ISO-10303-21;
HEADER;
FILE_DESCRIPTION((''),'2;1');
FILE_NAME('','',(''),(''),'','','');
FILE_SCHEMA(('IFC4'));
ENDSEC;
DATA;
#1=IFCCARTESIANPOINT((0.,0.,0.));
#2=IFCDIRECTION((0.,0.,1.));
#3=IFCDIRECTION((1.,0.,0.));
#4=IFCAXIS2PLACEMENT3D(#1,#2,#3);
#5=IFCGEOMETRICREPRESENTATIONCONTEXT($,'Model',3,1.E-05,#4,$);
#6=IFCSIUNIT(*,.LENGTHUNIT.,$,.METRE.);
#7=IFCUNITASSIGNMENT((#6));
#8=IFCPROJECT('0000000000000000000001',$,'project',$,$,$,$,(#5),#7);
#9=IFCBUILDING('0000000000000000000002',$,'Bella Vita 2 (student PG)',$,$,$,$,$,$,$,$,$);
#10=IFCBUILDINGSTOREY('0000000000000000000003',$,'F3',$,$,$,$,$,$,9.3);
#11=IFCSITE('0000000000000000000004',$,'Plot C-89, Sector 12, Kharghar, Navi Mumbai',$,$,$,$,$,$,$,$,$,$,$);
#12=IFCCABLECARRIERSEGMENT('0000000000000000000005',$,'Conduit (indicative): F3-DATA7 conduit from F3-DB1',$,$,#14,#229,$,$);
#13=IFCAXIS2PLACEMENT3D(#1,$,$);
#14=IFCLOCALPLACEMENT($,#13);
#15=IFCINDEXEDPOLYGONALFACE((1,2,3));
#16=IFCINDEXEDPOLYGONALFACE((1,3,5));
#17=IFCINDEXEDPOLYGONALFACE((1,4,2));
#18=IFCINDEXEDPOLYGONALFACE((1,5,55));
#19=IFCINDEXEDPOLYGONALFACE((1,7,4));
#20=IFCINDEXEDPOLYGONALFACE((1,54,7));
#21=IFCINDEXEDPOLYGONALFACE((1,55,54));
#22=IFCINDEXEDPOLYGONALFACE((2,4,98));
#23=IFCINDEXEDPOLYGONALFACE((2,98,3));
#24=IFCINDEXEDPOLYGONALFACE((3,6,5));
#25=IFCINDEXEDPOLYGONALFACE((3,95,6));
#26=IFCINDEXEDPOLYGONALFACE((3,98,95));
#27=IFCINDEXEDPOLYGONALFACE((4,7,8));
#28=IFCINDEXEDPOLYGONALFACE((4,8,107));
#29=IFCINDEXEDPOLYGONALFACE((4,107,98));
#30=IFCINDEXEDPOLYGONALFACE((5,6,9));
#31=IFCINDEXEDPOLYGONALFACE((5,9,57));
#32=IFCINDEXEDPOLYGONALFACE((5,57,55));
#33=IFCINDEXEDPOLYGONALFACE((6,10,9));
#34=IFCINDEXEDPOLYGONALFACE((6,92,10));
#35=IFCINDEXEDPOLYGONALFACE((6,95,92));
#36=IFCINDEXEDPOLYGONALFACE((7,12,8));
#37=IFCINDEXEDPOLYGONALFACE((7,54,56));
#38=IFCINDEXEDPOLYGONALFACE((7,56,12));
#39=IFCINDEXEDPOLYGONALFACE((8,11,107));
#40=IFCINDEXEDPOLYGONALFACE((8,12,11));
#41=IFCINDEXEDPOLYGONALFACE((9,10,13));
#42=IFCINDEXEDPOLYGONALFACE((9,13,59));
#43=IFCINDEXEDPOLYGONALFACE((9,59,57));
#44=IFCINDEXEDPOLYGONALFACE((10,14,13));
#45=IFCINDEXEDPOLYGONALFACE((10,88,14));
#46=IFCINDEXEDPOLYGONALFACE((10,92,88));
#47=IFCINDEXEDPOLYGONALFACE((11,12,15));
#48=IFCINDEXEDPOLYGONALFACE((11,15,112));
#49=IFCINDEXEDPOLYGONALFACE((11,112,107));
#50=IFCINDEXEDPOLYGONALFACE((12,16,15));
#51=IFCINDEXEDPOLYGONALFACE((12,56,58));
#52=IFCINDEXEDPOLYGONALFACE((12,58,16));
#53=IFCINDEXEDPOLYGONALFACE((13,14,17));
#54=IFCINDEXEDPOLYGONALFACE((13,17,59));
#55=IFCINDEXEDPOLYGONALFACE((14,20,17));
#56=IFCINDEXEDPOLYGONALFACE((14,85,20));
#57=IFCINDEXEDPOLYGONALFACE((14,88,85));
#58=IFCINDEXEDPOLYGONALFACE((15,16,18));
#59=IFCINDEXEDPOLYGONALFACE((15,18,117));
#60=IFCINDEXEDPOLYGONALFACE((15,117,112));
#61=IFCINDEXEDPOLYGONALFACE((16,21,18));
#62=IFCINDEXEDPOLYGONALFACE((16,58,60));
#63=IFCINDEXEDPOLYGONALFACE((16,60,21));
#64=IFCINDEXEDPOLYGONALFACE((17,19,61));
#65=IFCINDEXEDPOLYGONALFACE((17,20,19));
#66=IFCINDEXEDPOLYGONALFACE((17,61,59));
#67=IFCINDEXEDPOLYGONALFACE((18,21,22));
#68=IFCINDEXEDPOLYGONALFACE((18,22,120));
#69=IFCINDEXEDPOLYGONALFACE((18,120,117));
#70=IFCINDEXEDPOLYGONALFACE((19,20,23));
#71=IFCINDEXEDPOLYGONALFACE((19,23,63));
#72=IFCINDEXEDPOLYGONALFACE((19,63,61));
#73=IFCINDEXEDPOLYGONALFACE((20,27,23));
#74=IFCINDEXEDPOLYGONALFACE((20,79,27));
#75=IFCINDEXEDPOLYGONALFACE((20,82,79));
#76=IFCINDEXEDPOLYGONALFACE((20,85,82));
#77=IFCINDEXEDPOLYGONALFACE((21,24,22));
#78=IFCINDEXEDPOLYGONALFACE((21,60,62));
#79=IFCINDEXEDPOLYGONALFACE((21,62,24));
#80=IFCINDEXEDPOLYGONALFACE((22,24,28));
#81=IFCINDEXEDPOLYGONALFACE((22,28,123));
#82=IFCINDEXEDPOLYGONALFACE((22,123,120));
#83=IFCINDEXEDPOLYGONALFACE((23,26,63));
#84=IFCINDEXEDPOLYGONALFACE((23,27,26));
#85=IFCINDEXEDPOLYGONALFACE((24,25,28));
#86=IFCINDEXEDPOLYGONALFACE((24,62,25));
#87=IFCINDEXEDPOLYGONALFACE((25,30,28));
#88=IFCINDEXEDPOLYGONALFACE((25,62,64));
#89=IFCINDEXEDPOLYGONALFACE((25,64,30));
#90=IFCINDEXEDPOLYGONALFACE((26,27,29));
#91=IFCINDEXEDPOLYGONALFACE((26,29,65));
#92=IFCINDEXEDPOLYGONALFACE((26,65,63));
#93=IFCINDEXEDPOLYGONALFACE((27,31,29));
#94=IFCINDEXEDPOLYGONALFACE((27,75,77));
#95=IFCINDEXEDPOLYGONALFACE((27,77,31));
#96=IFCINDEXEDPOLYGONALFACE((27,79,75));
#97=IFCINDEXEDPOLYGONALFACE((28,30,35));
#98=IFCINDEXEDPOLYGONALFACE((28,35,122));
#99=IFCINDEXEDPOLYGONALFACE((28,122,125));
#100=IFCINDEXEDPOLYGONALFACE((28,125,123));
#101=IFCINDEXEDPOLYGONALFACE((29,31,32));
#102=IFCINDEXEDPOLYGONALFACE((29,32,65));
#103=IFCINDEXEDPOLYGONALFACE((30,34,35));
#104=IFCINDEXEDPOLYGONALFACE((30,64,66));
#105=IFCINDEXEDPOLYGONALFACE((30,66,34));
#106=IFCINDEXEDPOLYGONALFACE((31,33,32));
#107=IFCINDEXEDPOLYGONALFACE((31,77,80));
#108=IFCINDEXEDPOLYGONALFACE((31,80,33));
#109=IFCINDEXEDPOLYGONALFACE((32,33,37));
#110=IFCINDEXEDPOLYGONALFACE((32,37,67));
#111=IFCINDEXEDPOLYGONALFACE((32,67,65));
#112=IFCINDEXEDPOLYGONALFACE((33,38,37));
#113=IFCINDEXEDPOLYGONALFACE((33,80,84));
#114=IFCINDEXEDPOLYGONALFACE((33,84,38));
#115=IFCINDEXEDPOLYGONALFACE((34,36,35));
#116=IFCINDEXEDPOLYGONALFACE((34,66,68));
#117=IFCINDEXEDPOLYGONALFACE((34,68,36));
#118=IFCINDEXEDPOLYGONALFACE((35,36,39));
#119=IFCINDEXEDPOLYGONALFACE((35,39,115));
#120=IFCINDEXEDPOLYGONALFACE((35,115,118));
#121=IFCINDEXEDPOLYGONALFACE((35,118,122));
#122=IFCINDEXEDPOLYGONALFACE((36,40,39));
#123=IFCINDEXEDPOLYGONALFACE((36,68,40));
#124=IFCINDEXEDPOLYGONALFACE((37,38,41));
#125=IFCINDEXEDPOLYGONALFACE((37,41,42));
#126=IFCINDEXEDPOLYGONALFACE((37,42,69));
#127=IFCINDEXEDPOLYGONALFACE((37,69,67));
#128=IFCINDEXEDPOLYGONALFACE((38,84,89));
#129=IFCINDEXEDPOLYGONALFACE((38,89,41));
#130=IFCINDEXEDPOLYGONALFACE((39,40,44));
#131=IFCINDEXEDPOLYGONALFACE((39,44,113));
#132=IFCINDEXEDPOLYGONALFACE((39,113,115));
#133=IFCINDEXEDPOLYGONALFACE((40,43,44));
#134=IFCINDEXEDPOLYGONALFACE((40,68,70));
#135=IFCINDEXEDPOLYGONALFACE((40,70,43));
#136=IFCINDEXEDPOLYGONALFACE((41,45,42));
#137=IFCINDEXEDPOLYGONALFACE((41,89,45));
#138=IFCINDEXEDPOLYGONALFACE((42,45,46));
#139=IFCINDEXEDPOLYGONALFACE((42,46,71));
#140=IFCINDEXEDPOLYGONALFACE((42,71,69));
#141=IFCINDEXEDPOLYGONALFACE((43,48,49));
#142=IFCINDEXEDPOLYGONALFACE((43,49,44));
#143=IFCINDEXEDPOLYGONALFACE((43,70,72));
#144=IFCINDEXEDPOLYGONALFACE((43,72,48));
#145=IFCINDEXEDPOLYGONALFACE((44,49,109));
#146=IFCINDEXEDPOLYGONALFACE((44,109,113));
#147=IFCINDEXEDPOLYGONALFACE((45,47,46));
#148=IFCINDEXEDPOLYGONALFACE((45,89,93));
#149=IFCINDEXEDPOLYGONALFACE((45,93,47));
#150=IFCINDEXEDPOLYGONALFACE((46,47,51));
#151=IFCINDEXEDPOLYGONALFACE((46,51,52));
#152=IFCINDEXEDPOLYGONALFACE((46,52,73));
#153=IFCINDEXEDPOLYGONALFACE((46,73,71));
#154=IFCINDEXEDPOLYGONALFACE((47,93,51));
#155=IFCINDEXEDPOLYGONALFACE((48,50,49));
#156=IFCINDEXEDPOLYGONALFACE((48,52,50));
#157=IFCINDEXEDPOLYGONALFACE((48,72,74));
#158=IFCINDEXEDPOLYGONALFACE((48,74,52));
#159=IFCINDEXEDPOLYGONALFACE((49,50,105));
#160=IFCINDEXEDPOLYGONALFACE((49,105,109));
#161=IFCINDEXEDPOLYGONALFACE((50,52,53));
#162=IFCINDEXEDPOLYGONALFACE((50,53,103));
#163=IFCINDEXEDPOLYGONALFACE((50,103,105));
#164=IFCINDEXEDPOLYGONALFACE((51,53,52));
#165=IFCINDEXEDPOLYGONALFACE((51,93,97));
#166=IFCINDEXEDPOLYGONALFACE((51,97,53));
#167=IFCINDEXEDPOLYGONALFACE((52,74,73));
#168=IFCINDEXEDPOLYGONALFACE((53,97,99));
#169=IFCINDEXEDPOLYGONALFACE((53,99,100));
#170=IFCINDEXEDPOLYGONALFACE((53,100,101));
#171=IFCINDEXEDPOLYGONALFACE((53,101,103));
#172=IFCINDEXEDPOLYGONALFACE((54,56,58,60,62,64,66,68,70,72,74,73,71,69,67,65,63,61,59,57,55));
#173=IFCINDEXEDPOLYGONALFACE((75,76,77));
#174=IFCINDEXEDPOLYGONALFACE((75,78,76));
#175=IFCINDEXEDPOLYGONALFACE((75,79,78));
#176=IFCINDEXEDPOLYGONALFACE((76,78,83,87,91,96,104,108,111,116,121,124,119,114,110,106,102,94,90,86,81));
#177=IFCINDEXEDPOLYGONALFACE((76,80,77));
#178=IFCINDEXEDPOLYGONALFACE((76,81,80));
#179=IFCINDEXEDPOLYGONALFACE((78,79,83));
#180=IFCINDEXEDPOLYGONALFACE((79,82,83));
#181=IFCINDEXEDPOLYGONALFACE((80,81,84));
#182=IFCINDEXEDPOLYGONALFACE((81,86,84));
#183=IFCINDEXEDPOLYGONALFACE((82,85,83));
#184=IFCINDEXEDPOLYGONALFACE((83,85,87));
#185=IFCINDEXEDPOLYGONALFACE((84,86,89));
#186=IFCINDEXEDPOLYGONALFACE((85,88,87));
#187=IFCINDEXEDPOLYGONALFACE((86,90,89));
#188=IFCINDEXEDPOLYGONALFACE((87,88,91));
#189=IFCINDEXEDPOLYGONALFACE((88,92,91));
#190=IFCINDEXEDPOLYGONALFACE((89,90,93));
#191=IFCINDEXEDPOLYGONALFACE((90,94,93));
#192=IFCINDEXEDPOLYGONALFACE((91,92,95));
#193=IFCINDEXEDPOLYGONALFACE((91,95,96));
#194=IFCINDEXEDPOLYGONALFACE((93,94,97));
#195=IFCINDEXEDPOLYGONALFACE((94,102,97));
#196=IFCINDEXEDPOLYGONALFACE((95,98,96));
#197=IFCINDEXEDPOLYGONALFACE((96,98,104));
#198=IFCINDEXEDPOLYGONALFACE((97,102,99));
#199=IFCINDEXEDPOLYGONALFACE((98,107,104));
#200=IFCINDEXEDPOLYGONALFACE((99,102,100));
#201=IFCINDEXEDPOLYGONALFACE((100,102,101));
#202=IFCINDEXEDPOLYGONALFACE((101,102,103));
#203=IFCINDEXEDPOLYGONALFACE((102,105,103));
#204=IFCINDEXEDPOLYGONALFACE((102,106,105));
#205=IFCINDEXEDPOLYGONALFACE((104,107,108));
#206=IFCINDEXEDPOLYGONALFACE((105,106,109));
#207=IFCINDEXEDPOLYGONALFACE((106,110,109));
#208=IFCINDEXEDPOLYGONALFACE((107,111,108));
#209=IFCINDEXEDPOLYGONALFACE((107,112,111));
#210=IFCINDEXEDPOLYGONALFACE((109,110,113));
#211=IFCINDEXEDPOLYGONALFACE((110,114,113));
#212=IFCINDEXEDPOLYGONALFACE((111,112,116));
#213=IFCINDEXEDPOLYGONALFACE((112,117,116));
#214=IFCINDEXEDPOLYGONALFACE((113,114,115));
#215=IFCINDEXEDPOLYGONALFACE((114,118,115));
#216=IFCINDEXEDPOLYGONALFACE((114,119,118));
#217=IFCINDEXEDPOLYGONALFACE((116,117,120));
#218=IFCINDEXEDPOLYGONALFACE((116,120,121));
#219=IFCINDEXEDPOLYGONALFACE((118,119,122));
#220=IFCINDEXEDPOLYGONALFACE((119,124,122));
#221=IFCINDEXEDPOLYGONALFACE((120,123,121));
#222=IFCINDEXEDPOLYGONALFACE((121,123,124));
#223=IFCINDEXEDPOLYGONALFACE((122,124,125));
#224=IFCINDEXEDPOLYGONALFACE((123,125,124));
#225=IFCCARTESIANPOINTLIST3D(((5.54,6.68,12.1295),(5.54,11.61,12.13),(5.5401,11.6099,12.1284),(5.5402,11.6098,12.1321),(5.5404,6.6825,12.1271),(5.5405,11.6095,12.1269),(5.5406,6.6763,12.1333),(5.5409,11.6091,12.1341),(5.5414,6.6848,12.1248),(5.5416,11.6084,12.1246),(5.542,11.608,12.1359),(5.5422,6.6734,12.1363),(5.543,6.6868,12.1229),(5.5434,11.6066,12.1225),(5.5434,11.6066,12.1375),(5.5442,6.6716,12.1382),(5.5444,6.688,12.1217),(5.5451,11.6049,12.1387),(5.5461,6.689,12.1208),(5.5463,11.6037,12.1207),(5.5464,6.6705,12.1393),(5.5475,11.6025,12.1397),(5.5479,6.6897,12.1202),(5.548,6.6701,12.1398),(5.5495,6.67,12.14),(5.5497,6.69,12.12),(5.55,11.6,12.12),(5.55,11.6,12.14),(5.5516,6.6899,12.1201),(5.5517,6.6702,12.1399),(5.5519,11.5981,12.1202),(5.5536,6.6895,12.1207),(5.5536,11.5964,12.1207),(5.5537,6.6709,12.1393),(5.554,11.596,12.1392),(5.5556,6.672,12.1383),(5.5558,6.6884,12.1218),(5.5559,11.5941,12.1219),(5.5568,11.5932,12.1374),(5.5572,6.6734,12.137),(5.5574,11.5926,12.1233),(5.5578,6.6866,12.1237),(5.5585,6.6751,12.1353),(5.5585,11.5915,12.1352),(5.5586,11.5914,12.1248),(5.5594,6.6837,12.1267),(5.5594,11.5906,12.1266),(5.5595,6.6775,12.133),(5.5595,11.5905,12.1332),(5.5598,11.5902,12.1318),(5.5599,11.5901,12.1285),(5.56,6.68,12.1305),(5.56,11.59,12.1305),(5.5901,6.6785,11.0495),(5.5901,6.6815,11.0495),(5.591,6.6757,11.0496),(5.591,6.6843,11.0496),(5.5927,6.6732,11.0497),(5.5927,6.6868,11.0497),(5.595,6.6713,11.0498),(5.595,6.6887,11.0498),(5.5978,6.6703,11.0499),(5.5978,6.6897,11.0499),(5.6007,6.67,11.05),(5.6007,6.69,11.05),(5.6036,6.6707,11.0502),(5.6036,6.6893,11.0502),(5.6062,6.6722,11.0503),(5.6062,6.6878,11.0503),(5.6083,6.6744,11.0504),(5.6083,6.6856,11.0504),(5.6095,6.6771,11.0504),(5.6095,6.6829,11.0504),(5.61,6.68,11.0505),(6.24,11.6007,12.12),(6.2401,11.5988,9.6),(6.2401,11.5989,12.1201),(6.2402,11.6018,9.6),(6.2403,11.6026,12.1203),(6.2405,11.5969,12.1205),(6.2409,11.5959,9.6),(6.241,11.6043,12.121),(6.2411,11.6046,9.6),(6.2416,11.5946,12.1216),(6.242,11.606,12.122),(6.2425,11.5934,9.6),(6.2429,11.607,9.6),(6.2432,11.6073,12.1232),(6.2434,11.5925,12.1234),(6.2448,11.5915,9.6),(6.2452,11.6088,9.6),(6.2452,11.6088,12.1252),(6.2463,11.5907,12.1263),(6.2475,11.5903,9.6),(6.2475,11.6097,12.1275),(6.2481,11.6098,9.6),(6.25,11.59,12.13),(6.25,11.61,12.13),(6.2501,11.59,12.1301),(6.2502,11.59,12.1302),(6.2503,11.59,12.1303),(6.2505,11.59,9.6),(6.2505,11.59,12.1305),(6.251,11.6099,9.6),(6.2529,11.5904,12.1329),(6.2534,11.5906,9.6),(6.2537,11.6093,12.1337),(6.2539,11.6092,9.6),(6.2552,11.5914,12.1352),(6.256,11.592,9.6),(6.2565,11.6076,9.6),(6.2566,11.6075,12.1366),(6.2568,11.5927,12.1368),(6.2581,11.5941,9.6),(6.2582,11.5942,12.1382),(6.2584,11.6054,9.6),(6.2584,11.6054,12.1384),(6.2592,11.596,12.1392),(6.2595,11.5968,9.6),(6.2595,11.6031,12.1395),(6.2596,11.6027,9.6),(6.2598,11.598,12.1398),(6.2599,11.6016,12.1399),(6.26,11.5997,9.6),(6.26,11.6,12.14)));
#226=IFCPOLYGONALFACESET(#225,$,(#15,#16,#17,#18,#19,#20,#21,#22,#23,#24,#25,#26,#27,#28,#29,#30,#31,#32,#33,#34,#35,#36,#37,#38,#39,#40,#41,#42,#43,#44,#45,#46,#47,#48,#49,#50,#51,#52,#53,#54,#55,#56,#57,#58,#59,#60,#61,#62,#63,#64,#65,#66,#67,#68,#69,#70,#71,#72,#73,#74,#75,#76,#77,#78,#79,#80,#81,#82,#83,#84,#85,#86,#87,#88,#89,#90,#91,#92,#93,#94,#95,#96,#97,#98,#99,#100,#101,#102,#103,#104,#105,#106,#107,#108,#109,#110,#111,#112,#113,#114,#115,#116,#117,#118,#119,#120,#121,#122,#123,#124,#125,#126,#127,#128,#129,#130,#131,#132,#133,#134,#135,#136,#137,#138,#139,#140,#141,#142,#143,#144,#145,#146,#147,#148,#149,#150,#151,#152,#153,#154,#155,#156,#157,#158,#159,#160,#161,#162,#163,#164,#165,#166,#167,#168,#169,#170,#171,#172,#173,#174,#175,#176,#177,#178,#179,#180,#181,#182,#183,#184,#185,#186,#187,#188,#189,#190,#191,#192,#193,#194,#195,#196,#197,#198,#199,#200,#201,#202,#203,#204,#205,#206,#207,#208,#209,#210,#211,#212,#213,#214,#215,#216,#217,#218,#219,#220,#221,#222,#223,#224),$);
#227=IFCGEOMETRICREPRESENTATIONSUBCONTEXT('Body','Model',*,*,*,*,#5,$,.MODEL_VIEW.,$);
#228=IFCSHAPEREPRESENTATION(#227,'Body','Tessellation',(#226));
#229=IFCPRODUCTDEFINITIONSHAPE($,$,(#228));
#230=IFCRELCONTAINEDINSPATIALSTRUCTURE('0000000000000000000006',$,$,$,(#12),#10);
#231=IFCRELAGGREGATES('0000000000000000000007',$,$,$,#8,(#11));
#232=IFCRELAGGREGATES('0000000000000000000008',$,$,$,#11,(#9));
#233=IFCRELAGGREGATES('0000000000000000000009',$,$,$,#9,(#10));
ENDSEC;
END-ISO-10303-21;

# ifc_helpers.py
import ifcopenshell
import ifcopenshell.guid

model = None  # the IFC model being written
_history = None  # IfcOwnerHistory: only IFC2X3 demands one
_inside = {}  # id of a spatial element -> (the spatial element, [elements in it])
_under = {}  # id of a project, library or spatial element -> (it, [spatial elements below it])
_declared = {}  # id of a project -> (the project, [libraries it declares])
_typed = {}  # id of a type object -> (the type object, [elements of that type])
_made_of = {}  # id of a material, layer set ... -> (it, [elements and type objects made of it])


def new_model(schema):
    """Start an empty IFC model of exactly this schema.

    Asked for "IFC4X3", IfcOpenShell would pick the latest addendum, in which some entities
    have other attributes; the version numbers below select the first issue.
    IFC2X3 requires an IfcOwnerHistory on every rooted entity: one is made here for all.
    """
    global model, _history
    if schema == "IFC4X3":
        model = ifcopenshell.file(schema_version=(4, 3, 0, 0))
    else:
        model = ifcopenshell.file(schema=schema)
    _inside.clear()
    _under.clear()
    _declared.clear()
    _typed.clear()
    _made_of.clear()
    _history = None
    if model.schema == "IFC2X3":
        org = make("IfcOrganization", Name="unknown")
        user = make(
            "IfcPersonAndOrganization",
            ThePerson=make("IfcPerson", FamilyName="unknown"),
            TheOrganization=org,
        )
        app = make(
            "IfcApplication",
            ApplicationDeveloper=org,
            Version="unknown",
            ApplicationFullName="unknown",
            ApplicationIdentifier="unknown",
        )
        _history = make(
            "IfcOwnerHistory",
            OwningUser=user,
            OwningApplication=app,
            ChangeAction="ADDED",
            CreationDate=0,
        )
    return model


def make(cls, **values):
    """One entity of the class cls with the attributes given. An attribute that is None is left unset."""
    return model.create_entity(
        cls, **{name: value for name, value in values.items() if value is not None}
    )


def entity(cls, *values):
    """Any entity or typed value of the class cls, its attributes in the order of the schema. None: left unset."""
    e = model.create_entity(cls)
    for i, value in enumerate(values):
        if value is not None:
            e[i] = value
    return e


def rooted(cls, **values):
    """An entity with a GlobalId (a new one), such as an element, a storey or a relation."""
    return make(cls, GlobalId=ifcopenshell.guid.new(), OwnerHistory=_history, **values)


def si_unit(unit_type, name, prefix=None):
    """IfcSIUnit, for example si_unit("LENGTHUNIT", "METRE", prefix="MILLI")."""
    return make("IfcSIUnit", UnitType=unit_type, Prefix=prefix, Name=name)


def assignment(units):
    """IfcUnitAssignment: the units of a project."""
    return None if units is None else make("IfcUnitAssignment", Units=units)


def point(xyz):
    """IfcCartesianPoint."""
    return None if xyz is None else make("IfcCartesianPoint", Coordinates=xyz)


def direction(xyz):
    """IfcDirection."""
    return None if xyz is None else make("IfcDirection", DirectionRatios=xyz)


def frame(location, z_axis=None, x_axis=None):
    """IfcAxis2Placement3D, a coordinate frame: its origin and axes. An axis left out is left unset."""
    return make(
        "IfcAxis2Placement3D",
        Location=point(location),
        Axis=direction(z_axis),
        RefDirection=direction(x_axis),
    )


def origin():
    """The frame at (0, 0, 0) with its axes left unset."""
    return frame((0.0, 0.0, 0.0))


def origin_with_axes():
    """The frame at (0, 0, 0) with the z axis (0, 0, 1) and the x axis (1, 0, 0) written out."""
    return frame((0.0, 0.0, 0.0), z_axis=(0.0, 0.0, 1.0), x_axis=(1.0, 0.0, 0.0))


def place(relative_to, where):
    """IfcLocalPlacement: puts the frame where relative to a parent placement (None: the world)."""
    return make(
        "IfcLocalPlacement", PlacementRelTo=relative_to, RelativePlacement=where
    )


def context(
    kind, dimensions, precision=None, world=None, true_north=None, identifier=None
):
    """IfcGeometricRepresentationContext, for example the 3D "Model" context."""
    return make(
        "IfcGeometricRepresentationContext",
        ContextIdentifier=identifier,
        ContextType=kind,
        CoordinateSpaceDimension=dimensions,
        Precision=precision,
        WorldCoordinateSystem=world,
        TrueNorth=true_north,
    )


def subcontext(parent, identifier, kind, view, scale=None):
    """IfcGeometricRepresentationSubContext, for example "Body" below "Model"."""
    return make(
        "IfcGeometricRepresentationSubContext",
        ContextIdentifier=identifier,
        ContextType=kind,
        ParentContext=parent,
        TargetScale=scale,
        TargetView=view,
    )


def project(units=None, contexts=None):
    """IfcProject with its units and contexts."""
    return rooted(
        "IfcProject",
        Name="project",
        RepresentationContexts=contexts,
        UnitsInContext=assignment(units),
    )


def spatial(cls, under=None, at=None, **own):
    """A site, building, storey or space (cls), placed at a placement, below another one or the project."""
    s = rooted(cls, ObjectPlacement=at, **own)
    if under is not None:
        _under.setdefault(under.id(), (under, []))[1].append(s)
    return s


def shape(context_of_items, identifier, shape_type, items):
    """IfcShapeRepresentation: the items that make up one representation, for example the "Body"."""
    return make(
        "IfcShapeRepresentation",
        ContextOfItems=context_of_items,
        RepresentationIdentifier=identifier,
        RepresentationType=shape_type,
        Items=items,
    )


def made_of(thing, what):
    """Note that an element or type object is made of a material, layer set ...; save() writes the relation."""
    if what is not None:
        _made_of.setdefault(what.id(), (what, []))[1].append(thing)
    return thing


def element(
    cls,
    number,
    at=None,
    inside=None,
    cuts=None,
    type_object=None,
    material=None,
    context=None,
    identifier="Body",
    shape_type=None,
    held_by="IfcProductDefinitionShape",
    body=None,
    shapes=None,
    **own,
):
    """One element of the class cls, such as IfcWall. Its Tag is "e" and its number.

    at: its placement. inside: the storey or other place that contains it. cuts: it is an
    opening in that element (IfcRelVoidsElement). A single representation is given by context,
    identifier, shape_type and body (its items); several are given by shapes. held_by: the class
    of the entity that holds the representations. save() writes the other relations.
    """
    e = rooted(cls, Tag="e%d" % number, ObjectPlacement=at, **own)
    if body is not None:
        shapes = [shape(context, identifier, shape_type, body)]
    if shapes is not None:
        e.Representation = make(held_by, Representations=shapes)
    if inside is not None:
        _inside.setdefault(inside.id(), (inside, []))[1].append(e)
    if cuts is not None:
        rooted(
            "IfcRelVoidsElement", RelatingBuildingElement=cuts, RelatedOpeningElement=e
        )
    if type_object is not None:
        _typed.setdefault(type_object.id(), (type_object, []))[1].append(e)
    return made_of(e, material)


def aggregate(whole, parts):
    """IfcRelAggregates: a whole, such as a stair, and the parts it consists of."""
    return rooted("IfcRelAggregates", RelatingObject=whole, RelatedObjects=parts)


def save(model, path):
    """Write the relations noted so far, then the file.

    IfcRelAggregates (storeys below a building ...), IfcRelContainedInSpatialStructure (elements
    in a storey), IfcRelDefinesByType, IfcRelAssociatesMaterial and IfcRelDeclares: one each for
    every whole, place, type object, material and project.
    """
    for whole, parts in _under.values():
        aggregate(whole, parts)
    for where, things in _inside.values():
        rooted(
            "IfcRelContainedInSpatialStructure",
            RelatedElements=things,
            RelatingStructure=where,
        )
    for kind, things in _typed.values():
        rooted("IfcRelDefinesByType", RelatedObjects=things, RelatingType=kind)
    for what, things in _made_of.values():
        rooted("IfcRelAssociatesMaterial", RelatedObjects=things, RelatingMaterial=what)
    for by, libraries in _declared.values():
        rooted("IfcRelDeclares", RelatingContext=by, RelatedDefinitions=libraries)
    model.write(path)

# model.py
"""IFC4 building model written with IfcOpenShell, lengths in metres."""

from ifc_helpers import new_model, entity, si_unit, origin, origin_with_axes, place, context, subcontext, project, spatial, element, save


model = new_model("IFC4")

# Units and contexts
model_context = context("Model", 3, precision=1e-05, world=origin_with_axes())
body_context = subcontext(model_context, "Body", "Model", "MODEL_VIEW")
ifc_project = project(units=[si_unit("LENGTHUNIT", "METRE")], contexts=[model_context])

# Site, building, storey
site = spatial("IfcSite", under=ifc_project, Name="Plot C-89, Sector 12, Kharghar, Navi Mumbai")
building = spatial("IfcBuilding", under=site, Name="Bella Vita 2 (student PG)")
storey = spatial("IfcBuildingStorey", under=building, Name="F3", Elevation=9.3)

# Cable carrier segment
cable_carrier_segment_1_placement = place(None, origin())
element("IfcCableCarrierSegment", 1, at=cable_carrier_segment_1_placement, inside=storey, Name="Conduit (indicative): F3-DATA7 conduit from F3-DB1", context=body_context, shape_type="AdvancedSweptSolid", body=[
    entity("IfcSweptDiskSolid", entity("IfcPolyline", [entity("IfcCartesianPoint", [5.6, 6.68, 11.05]), entity("IfcCartesianPoint", [5.55, 6.68, 12.13]), entity("IfcCartesianPoint", [5.55, 11.6, 12.13]), entity("IfcCartesianPoint", [6.25, 11.6, 12.13]), entity("IfcCartesianPoint", [6.25, 11.6, 9.6])]), 0.01),
])

save(model, "model.ifc")
